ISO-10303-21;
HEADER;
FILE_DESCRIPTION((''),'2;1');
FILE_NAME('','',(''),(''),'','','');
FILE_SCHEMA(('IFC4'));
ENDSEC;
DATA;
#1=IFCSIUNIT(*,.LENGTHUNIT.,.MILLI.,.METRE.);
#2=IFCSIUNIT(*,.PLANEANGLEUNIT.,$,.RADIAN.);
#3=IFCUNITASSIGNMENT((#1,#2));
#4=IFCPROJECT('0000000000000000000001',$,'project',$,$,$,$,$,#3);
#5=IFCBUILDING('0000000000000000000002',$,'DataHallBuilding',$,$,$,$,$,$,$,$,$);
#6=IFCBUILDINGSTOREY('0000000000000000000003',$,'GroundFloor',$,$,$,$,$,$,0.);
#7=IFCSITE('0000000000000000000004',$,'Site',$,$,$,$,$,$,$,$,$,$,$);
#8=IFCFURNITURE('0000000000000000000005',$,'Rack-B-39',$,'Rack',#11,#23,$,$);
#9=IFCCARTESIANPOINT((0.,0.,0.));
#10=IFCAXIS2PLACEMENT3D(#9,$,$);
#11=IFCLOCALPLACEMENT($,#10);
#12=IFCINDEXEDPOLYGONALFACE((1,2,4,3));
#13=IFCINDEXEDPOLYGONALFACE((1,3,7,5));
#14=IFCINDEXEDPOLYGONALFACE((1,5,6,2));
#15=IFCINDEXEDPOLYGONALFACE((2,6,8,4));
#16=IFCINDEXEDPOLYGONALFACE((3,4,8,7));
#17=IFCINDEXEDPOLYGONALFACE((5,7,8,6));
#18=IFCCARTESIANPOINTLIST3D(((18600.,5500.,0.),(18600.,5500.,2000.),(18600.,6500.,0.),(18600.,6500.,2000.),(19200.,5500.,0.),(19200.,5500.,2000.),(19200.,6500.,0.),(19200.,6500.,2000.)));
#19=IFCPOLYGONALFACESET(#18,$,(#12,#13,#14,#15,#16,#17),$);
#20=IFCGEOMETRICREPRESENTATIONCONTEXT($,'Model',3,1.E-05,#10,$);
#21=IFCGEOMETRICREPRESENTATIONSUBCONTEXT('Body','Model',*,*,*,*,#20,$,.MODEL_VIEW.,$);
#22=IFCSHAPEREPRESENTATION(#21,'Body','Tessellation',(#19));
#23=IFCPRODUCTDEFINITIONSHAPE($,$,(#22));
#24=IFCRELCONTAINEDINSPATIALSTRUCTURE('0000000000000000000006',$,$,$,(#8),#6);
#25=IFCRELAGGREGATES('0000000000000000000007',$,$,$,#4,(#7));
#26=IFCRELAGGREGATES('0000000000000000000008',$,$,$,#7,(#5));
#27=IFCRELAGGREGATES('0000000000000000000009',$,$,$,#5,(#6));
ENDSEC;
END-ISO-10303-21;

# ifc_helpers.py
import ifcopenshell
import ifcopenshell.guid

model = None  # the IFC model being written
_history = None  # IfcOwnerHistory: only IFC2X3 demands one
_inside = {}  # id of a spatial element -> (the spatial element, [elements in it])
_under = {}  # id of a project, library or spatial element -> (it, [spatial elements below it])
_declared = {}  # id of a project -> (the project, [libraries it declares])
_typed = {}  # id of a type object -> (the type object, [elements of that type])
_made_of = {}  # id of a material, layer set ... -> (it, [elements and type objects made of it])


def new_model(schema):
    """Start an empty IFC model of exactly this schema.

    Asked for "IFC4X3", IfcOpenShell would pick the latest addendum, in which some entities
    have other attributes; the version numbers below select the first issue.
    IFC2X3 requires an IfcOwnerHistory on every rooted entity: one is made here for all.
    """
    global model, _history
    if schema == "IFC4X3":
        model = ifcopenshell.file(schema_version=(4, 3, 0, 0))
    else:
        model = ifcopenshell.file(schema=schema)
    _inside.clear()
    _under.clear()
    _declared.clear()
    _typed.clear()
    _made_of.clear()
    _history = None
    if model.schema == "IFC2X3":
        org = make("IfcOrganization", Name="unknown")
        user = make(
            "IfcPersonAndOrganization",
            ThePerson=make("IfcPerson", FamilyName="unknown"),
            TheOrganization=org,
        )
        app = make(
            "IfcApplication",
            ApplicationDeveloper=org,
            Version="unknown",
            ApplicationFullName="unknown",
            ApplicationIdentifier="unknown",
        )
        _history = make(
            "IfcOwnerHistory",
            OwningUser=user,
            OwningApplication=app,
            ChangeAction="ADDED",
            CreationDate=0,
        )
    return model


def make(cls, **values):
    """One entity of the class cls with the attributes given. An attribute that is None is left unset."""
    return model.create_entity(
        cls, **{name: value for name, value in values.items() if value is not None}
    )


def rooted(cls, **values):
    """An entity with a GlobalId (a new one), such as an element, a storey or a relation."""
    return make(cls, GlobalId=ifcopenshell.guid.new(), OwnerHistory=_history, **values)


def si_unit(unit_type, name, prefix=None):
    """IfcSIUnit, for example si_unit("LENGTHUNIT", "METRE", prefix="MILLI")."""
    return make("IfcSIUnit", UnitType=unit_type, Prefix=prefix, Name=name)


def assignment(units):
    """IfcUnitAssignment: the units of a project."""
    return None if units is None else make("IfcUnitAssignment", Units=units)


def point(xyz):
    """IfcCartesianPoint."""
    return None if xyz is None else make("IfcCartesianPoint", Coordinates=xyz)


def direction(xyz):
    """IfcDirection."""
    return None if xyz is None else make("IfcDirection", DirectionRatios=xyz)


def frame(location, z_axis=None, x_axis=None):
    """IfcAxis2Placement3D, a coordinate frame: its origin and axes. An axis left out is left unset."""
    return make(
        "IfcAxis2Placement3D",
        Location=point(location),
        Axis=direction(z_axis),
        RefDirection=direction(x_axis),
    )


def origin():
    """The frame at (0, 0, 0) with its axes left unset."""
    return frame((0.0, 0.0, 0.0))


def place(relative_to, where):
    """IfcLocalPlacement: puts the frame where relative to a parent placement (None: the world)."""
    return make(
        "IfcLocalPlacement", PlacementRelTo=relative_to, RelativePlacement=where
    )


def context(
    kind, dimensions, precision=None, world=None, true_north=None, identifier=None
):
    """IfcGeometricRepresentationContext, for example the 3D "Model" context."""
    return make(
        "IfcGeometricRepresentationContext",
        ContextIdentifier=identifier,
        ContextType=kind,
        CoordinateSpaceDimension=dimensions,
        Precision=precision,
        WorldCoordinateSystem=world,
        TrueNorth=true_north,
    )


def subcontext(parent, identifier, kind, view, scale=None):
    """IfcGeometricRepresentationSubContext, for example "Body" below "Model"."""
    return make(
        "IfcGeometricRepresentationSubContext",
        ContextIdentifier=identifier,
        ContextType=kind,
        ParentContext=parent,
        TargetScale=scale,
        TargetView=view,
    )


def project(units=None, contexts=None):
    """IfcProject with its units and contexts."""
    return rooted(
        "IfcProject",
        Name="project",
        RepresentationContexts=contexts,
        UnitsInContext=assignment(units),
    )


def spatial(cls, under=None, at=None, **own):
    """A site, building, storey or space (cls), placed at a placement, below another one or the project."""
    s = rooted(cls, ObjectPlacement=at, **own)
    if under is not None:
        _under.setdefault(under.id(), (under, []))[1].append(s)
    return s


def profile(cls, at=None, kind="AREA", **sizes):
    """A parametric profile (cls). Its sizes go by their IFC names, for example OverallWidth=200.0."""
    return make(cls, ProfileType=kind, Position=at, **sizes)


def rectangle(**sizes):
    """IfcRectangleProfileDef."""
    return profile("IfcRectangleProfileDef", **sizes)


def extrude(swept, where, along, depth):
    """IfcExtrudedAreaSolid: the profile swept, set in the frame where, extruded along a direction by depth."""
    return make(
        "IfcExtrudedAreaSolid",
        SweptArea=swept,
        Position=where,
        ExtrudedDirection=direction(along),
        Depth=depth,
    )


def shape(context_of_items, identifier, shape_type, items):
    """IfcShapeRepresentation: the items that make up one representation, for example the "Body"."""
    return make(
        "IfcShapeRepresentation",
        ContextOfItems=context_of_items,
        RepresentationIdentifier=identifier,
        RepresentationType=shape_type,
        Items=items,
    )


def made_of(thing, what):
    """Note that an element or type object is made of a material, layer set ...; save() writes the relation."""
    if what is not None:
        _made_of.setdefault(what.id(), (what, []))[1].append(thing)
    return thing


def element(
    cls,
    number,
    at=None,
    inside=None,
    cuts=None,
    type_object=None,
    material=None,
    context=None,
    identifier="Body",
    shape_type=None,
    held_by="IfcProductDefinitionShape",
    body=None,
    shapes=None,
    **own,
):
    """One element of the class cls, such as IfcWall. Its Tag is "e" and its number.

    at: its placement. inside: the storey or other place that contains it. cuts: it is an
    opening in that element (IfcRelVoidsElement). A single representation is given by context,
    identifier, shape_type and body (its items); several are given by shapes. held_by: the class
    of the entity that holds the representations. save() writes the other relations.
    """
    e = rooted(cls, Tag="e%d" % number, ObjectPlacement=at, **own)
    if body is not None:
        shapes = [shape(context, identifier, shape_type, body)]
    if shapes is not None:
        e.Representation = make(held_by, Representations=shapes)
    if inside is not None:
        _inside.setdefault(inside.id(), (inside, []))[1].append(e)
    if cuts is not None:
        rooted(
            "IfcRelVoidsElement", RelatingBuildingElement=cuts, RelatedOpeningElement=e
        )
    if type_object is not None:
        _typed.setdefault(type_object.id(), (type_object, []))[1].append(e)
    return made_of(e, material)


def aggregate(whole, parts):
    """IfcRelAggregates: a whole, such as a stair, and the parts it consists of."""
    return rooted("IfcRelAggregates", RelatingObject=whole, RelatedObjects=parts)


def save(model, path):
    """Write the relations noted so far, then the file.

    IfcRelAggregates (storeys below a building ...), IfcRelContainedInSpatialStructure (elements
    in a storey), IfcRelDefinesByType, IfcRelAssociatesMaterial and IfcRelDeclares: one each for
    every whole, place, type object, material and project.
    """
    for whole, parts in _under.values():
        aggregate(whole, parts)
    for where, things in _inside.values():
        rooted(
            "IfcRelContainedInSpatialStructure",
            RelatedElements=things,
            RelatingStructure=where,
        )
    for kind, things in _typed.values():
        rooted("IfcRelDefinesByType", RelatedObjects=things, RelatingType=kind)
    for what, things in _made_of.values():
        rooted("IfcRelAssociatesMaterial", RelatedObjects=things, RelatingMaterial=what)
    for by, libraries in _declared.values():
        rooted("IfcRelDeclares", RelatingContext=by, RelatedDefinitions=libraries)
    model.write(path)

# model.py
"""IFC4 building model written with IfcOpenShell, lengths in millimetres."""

from ifc_helpers import new_model, si_unit, frame, origin, place, context, subcontext, project, spatial, rectangle, extrude, element, save


model = new_model("IFC4")

# Units and contexts
model_context = context("Model", 3, precision=1e-05, world=origin())
body_context = subcontext(model_context, "Body", "Model", "MODEL_VIEW")
ifc_project = project(units=[si_unit("LENGTHUNIT", "METRE", prefix="MILLI"), si_unit("PLANEANGLEUNIT", "RADIAN")])

# Site, building, storey
site = spatial("IfcSite", under=ifc_project, Name="Site")
building = spatial("IfcBuilding", under=site, Name="DataHallBuilding")
storey = spatial("IfcBuildingStorey", under=building, Name="GroundFloor", Elevation=0.0)

# Furniture
furniture_1_placement = place(None, origin())
element("IfcFurniture", 1, at=furniture_1_placement, inside=storey, Name="Rack-B-39", ObjectType="Rack", context=body_context, shape_type="SweptSolid", body=[
    extrude(rectangle(XDim=600.0, YDim=1000.0), frame((18900.0, 6000.0, 0.0), z_axis=(0.0, 0.0, 1.0), x_axis=(1.0, 0.0, 0.0)), (0.0, 0.0, 1.0), 2000.0),
])

save(model, "model.ifc")
